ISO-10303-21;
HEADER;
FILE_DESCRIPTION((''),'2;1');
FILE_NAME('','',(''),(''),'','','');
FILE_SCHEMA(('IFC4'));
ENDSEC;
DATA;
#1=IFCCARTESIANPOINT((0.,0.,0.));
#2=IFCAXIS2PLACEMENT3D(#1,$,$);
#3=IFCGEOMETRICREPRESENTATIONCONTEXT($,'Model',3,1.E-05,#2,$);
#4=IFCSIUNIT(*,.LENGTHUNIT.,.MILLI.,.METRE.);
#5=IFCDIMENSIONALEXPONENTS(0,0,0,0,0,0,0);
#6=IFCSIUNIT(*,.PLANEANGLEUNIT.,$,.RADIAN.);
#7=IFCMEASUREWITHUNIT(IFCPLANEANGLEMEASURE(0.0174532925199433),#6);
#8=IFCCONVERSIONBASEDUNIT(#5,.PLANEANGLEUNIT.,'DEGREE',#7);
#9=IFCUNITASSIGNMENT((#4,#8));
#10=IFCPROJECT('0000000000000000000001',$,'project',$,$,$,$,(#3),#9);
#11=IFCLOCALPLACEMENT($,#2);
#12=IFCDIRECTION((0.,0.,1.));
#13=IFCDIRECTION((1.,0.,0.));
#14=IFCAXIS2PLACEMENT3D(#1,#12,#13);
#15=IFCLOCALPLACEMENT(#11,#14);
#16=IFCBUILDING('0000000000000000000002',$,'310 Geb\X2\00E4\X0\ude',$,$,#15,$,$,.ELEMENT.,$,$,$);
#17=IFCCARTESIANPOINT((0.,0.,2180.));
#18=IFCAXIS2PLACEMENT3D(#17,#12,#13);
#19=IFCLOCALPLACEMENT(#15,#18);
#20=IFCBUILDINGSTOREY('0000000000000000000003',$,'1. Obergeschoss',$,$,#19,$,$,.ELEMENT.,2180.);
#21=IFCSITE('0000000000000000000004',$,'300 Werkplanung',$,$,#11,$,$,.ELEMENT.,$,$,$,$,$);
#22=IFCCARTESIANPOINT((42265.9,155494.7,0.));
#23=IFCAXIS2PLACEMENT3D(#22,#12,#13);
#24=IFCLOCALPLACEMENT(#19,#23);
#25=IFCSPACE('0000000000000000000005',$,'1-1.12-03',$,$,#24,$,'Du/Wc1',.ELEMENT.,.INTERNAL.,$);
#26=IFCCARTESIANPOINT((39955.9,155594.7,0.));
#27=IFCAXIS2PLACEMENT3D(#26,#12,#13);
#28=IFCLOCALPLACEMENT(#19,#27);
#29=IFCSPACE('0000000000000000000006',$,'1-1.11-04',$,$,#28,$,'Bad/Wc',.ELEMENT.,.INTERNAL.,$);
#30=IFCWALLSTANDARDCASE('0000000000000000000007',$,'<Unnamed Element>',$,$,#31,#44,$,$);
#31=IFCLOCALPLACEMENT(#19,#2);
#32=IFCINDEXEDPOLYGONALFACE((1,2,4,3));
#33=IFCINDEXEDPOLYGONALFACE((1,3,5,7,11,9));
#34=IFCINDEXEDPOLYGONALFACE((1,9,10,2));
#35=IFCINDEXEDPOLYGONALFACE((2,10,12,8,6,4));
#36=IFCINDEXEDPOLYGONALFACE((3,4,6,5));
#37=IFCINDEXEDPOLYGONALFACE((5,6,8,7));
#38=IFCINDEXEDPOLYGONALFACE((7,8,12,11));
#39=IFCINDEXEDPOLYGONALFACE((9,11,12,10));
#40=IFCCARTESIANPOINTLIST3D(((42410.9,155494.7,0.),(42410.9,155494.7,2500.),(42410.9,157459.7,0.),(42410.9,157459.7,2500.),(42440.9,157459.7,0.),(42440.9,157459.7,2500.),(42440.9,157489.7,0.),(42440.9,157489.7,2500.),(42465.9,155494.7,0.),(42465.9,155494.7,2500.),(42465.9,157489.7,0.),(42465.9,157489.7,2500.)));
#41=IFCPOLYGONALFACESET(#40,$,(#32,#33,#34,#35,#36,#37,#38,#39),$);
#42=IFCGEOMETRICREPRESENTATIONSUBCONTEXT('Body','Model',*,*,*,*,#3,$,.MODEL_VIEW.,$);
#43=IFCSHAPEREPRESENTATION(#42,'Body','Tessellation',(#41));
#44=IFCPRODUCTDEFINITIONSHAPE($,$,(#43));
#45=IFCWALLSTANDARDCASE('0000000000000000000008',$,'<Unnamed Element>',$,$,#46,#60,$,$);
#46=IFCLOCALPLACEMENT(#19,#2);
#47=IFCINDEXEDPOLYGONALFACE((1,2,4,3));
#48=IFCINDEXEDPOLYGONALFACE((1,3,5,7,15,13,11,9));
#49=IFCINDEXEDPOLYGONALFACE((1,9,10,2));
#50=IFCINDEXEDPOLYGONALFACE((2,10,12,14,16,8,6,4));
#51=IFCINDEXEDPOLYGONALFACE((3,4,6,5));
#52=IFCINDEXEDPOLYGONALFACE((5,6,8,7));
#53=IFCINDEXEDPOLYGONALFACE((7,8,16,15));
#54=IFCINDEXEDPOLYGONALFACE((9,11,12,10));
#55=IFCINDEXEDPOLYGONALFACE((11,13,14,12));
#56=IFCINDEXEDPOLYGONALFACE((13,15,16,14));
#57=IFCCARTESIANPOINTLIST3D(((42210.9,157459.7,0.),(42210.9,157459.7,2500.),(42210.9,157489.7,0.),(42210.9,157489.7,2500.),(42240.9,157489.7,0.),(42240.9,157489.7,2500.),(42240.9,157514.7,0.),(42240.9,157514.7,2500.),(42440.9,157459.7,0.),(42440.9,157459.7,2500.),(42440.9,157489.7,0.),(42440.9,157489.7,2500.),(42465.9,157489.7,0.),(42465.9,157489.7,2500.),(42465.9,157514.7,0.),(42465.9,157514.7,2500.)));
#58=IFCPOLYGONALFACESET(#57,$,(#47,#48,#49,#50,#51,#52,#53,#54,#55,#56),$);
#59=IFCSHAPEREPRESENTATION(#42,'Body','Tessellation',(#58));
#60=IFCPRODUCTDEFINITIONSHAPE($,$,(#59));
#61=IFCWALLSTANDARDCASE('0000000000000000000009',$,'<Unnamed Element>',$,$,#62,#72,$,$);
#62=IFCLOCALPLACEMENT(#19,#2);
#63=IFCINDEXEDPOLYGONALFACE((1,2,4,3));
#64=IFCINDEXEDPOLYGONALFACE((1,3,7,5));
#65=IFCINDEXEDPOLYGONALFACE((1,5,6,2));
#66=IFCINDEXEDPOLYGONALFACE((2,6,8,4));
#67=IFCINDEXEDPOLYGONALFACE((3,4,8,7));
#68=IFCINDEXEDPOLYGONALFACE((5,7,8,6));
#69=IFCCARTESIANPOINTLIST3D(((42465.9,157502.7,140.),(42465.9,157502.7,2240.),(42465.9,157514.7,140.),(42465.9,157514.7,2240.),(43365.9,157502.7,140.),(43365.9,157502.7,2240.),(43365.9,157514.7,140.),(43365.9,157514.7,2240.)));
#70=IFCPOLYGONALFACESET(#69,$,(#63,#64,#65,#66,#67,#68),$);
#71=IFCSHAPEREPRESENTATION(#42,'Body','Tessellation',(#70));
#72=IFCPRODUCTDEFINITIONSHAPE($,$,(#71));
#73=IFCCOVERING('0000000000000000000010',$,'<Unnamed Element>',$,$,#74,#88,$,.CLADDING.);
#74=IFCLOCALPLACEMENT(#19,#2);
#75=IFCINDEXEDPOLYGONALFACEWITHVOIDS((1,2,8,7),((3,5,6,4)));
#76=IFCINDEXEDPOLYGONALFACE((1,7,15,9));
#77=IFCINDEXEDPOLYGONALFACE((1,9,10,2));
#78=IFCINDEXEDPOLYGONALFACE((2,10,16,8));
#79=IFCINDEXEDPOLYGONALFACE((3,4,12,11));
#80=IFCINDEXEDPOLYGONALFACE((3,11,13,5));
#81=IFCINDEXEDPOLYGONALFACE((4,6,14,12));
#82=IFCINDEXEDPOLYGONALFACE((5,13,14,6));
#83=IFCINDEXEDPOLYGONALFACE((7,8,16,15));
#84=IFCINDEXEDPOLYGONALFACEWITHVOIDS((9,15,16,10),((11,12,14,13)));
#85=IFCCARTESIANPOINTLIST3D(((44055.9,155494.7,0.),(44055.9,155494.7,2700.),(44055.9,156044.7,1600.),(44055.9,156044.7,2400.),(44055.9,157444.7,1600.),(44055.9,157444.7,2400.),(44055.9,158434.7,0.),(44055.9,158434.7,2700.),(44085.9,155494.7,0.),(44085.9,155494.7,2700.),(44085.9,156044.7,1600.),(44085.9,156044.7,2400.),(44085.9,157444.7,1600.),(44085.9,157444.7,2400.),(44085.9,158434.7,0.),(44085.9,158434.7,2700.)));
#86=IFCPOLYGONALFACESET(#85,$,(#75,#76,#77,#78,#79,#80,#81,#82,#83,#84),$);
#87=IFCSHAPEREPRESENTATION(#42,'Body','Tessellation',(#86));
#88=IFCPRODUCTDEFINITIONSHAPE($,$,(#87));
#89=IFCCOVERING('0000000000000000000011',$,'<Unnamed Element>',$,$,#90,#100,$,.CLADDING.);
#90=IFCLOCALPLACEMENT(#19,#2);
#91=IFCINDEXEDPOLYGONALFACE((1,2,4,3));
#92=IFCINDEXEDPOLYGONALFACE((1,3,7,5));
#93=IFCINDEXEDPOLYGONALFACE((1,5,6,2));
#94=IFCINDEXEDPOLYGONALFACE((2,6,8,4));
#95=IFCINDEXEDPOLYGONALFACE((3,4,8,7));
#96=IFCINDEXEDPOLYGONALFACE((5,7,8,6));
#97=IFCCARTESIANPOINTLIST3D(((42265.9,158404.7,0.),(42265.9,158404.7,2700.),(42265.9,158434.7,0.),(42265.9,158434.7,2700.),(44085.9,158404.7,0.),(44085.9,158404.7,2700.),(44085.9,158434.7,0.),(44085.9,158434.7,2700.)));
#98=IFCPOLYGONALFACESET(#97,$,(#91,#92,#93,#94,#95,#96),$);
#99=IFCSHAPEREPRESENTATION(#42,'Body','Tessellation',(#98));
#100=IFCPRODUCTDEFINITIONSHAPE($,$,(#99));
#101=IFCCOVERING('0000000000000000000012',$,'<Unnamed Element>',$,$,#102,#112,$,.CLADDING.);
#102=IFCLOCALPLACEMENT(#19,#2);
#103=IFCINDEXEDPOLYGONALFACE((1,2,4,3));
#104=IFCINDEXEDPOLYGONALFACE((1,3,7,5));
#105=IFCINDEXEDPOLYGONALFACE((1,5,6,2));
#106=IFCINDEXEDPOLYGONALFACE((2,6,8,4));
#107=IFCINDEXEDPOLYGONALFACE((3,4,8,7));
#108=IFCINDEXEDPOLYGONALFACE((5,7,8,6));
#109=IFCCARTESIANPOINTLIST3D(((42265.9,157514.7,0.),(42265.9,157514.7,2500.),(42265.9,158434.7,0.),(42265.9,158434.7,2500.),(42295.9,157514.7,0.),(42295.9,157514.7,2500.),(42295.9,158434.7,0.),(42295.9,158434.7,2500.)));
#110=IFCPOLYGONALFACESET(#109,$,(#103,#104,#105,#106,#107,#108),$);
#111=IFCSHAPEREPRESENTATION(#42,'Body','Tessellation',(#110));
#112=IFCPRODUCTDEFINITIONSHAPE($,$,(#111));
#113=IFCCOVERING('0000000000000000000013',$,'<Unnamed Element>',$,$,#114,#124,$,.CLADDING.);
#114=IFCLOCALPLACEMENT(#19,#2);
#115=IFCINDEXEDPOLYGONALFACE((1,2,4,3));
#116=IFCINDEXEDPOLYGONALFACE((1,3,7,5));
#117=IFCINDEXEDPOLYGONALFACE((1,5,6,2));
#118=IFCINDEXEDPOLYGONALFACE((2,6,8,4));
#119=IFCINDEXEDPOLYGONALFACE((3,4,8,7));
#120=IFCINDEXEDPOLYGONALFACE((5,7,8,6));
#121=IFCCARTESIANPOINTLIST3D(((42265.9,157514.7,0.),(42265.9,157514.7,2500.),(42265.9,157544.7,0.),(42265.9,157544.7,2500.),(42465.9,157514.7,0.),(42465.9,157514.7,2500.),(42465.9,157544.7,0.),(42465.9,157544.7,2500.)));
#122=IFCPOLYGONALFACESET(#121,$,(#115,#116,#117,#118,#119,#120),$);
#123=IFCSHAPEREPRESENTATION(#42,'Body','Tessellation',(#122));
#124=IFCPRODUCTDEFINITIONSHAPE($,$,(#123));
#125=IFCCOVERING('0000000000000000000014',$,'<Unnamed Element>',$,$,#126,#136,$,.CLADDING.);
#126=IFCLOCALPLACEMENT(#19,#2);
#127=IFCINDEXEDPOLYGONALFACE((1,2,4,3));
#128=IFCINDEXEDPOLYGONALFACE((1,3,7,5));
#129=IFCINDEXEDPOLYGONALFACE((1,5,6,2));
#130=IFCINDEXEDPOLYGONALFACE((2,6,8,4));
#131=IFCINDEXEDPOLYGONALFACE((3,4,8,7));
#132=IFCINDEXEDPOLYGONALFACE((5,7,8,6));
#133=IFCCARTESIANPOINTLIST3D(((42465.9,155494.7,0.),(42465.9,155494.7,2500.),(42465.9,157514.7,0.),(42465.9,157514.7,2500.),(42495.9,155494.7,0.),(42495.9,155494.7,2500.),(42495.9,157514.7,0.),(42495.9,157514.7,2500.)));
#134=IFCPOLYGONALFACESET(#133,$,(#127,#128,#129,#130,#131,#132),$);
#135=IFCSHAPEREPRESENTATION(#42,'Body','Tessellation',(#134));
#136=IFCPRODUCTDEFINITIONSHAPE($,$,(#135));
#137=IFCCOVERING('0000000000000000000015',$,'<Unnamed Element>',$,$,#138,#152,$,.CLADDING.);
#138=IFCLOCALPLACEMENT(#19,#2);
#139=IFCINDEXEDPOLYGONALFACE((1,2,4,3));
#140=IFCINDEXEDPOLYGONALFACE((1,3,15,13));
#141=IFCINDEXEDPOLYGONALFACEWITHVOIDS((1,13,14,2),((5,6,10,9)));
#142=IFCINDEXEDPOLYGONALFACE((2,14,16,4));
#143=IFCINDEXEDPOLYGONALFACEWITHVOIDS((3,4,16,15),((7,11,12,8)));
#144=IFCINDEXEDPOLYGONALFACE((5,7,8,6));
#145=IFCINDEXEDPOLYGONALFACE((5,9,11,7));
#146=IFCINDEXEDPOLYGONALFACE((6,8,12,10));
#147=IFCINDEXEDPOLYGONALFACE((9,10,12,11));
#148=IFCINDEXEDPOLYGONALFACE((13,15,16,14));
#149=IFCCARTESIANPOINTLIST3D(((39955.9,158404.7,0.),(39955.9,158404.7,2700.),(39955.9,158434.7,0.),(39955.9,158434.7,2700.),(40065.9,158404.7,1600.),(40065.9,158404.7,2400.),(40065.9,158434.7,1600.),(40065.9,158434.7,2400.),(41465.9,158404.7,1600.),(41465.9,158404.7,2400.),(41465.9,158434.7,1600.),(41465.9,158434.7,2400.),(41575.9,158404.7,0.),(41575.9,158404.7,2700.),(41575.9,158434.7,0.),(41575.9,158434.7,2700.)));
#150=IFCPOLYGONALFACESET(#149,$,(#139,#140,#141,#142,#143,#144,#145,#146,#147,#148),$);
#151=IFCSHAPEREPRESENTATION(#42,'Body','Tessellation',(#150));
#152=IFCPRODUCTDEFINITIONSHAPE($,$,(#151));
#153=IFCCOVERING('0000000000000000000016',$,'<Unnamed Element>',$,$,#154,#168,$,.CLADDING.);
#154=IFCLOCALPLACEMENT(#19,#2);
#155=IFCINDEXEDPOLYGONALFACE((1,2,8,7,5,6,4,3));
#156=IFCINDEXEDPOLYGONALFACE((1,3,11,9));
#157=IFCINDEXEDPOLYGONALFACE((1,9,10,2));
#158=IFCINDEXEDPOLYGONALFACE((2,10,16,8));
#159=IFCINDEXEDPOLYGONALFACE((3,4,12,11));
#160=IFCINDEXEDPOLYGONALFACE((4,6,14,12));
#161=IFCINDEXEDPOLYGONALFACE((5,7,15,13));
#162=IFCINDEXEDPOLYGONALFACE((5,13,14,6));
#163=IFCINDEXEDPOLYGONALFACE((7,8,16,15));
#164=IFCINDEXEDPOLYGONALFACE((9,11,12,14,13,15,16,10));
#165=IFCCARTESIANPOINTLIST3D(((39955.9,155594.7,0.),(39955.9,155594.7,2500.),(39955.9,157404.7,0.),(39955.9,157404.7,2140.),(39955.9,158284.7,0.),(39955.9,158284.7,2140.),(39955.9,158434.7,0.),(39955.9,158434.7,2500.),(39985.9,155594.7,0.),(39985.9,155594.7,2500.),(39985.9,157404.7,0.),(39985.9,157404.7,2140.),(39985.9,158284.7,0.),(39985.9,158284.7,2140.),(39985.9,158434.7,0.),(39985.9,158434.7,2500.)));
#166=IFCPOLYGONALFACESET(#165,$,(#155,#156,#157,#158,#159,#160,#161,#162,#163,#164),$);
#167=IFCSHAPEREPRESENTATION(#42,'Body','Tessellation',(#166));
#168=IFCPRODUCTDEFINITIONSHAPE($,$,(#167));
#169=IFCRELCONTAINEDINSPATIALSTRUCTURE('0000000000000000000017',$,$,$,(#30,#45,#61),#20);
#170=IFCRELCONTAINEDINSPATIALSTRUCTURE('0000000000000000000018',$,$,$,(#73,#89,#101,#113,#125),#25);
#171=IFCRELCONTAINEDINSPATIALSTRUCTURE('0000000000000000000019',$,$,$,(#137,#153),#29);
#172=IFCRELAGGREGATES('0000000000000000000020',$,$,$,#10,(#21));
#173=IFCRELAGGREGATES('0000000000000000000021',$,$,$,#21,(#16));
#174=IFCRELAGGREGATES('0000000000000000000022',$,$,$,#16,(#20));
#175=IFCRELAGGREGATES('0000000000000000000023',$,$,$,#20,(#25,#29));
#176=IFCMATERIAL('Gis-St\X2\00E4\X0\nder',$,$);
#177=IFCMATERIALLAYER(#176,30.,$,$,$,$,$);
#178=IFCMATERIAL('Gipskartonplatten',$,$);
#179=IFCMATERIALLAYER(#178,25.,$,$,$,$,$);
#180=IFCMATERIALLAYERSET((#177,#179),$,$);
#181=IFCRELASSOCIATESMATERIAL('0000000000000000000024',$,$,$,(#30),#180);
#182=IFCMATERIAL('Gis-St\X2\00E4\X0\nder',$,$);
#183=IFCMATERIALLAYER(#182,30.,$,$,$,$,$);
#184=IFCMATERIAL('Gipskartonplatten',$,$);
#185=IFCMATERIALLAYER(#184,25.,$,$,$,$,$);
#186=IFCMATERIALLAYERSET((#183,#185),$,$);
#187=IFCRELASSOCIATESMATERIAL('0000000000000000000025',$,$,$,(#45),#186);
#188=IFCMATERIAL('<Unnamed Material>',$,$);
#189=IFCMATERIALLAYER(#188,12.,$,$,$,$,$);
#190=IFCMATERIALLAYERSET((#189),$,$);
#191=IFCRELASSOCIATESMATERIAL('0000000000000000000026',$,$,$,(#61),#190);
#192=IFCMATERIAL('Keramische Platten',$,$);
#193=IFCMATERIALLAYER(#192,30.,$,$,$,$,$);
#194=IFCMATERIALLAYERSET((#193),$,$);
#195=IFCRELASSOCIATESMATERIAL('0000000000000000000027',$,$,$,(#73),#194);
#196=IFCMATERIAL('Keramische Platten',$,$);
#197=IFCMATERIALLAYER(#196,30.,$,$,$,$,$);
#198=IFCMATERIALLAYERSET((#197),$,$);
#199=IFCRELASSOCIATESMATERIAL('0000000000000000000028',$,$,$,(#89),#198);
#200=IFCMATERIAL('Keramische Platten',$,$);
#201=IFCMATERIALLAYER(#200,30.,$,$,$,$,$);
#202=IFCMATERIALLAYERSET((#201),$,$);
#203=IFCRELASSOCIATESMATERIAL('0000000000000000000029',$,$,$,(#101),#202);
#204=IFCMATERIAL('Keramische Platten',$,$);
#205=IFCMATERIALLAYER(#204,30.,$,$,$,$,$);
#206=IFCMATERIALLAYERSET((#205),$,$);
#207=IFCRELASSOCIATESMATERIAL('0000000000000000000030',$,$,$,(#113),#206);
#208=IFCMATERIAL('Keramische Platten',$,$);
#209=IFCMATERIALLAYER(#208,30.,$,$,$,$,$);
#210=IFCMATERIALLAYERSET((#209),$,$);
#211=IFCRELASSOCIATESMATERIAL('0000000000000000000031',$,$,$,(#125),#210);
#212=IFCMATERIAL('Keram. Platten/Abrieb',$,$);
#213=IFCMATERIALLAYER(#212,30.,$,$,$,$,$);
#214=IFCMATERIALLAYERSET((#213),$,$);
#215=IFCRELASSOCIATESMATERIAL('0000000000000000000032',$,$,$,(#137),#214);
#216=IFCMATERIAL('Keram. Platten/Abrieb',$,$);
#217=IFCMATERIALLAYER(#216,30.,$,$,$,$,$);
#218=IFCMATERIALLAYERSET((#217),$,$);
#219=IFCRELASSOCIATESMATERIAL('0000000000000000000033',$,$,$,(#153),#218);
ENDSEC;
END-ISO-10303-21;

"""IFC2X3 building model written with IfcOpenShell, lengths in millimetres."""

from ifc_helpers import new_model, entity, si_unit, converted_unit, frame, frame_2d, origin, origin_with_axes, place, context, subcontext, project, spatial, polyline, rectangle, outline, extrude, material, layer, layer_set, layer_usage, element, save


model = new_model("IFC2X3")

# Units and contexts
model_context = context("Model", 3, precision=1e-05, world=origin())
body_context = subcontext(model_context, "Body", "Model", "MODEL_VIEW")
ifc_project = project(units=[si_unit("LENGTHUNIT", "METRE", prefix="MILLI"), converted_unit("PLANEANGLEUNIT", "DEGREE", entity("IfcPlaneAngleMeasure", 0.0174532925199433), si_unit("PLANEANGLEUNIT", "RADIAN"), dimensions=[0, 0, 0, 0, 0, 0, 0])], contexts=[model_context])

# Site, building, storey
site_placement = place(None, origin())
site = spatial("IfcSite", under=ifc_project, at=site_placement, Name="300 Werkplanung", CompositionType="ELEMENT")
building_placement = place(site_placement, origin_with_axes())
building = spatial("IfcBuilding", under=site, at=building_placement, Name="310 Gebäude", CompositionType="ELEMENT")
storey_placement = place(building_placement, frame((0.0, 0.0, 2180.0), z_axis=(0.0, 0.0, 1.0), x_axis=(1.0, 0.0, 0.0)))
storey = spatial("IfcBuildingStorey", under=building, at=storey_placement, Name="1. Obergeschoss", CompositionType="ELEMENT", Elevation=2180.0)

# Walls
ifc_material_1 = material(Name="Gis-Ständer")
ifc_layer_1 = layer(ifc_material_1, 30.0)
ifc_material_2 = material(Name="Gipskartonplatten")
ifc_layer_2 = layer(ifc_material_2, 25.0)
ifc_layer_set_1 = layer_set([ifc_layer_1, ifc_layer_2])
ifc_layer_usage_1 = layer_usage(ifc_layer_set_1, "AXIS2", "POSITIVE", -55.0)
wall_1_placement = place(storey_placement, frame((42410.9, 157459.7, 0.0), z_axis=(0.0, 0.0, 1.0), x_axis=(0.0, -1.0, 0.0)))
element("IfcWallStandardCase", 1, at=wall_1_placement, inside=storey, material=ifc_layer_usage_1, Name="<Unnamed Element>", context=body_context, shape_type="SweptSolid", body=[
    extrude(outline(polyline([(-30.0, 55.0), (-30.0, 30.0), (0.0, 30.0), (0.0, 0.0), (1965.0, 0.0), (1965.0, 55.0), (-30.0, 55.0)])), origin_with_axes(), (0.0, 0.0, 1.0), 2500.0),
])
ifc_material_3 = material(Name="Gis-Ständer")
ifc_layer_3 = layer(ifc_material_3, 30.0)
ifc_material_4 = material(Name="Gipskartonplatten")
ifc_layer_4 = layer(ifc_material_4, 25.0)
ifc_layer_set_2 = layer_set([ifc_layer_3, ifc_layer_4])
ifc_layer_usage_2 = layer_usage(ifc_layer_set_2, "AXIS2", "POSITIVE", -55.0)
wall_2_placement = place(storey_placement, frame((42210.9, 157459.7, 0.0), z_axis=(0.0, 0.0, 1.0), x_axis=(1.0, 0.0, 0.0)))
element("IfcWallStandardCase", 2, at=wall_2_placement, inside=storey, material=ifc_layer_usage_2, Name="<Unnamed Element>", context=body_context, shape_type="SweptSolid", body=[
    extrude(outline(polyline([(0.0, 0.0), (230.0, 0.0), (230.0, 30.0), (255.0, 30.0), (255.0, 55.0), (30.0, 55.0), (30.0, 30.0), (0.0, 30.0), (0.0, 0.0)])), origin_with_axes(), (0.0, 0.0, 1.0), 2500.0),
])
ifc_material_5 = material(Name="<Unnamed Material>")
ifc_layer_5 = layer(ifc_material_5, 12.0)
ifc_layer_set_3 = layer_set([ifc_layer_5])
ifc_layer_usage_3 = layer_usage(ifc_layer_set_3, "AXIS2", "POSITIVE", 0.0)
wall_3_placement = place(storey_placement, frame((43365.9, 157514.7, 140.0), z_axis=(0.0, 0.0, 1.0), x_axis=(-1.0, 0.0, 0.0)))
element("IfcWallStandardCase", 3, at=wall_3_placement, inside=storey, material=ifc_layer_usage_3, Name="<Unnamed Element>", context=body_context, shape_type="SweptSolid", body=[
    extrude(rectangle(XDim=900.0, YDim=12.0, at=frame_2d((450.0, 6.0), x_axis=(1.0, 0.0))), origin_with_axes(), (0.0, 0.0, 1.0), 2100.0),
])

# Shared definitions
space_1_placement = place(storey_placement, frame((42265.9, 155494.7, 0.0), z_axis=(0.0, 0.0, 1.0), x_axis=(1.0, 0.0, 0.0)))
space_1 = spatial("IfcSpace", under=storey, at=space_1_placement, Name="1-1.12-03", LongName="Du/Wc1", CompositionType="ELEMENT", InteriorOrExteriorSpace="INTERNAL")

# Coverings
ifc_material_6 = material(Name="Keramische Platten")
ifc_layer_6 = layer(ifc_material_6, 30.0)
ifc_layer_set_4 = layer_set([ifc_layer_6])
ifc_layer_usage_4 = layer_usage(ifc_layer_set_4, "AXIS3", "POSITIVE", 0.0)
covering_1_placement = place(space_1_placement, frame((1820.0, 0.0, 0.0), z_axis=(0.0, 0.0, 1.0), x_axis=(0.0, 1.0, 0.0)))
element("IfcCovering", 4, at=covering_1_placement, inside=space_1, material=ifc_layer_usage_4, Name="<Unnamed Element>", PredefinedType="CLADDING", context=body_context, shape_type="SweptSolid", body=[
    extrude(outline(polyline([(2940.0, 0.0), (2940.0, -2700.0), (0.0, -2700.0), (0.0, 0.0), (2940.0, 0.0)]), holes=[polyline([(1950.0, -1600.0), (550.0, -1600.0), (550.0, -2400.0), (1950.0, -2400.0), (1950.0, -1600.0)])]), frame((0.0, 0.0, 0.0), z_axis=(0.0, 1.0, 0.0), x_axis=(1.0, 0.0, 0.0)), (0.0, 0.0, 1.0), 30.0),
])
ifc_material_7 = material(Name="Keramische Platten")
ifc_layer_7 = layer(ifc_material_7, 30.0)
ifc_layer_set_5 = layer_set([ifc_layer_7])
ifc_layer_usage_5 = layer_usage(ifc_layer_set_5, "AXIS3", "POSITIVE", 0.0)
covering_2_placement = place(space_1_placement, frame((1820.0, 2940.0, 0.0), z_axis=(0.0, 0.0, 1.0), x_axis=(-1.0, 0.0, 0.0)))
element("IfcCovering", 5, at=covering_2_placement, inside=space_1, material=ifc_layer_usage_5, Name="<Unnamed Element>", PredefinedType="CLADDING", context=body_context, shape_type="SweptSolid", body=[
    extrude(rectangle(XDim=2700.0, YDim=1820.0, at=frame_2d((-910.0, 1350.0), x_axis=(0.0, 1.0))), frame((1820.0, 0.0, 2700.0), z_axis=(0.0, 1.0, 0.0), x_axis=(1.0, 0.0, 0.0)), (0.0, 0.0, 1.0), 30.0),
])
ifc_material_8 = material(Name="Keramische Platten")
ifc_layer_8 = layer(ifc_material_8, 30.0)
ifc_layer_set_6 = layer_set([ifc_layer_8])
ifc_layer_usage_6 = layer_usage(ifc_layer_set_6, "AXIS3", "POSITIVE", 0.0)
covering_3_placement = place(space_1_placement, frame((0.0, 2940.0, 0.0), z_axis=(0.0, 0.0, 1.0), x_axis=(0.0, -1.0, 0.0)))
element("IfcCovering", 6, at=covering_3_placement, inside=space_1, material=ifc_layer_usage_6, Name="<Unnamed Element>", PredefinedType="CLADDING", context=body_context, shape_type="SweptSolid", body=[
    extrude(rectangle(XDim=2500.0, YDim=920.0, at=frame_2d((-460.0, 1250.0), x_axis=(0.0, 1.0))), frame((920.0, 0.0, 2500.0), z_axis=(0.0, 1.0, 0.0), x_axis=(1.0, 0.0, 0.0)), (0.0, 0.0, 1.0), 30.0),
])
ifc_material_9 = material(Name="Keramische Platten")
ifc_layer_9 = layer(ifc_material_9, 30.0)
ifc_layer_set_7 = layer_set([ifc_layer_9])
ifc_layer_usage_7 = layer_usage(ifc_layer_set_7, "AXIS3", "POSITIVE", 0.0)
covering_4_placement = place(space_1_placement, frame((0.0, 2020.0, 0.0), z_axis=(0.0, 0.0, 1.0), x_axis=(1.0, 0.0, 0.0)))
element("IfcCovering", 7, at=covering_4_placement, inside=space_1, material=ifc_layer_usage_7, Name="<Unnamed Element>", PredefinedType="CLADDING", context=body_context, shape_type="SweptSolid", body=[
    extrude(rectangle(XDim=2500.0, YDim=200.0, at=frame_2d((-100.0, 1250.0), x_axis=(0.0, 1.0))), frame((200.0, 0.0, 2500.0), z_axis=(0.0, 1.0, 0.0), x_axis=(1.0, 0.0, 0.0)), (0.0, 0.0, 1.0), 30.0),
])
ifc_material_10 = material(Name="Keramische Platten")
ifc_layer_10 = layer(ifc_material_10, 30.0)
ifc_layer_set_8 = layer_set([ifc_layer_10])
ifc_layer_usage_8 = layer_usage(ifc_layer_set_8, "AXIS3", "POSITIVE", 0.0)
covering_5_placement = place(space_1_placement, frame((200.0, 2020.0, 0.0), z_axis=(0.0, 0.0, 1.0), x_axis=(0.0, -1.0, 0.0)))
element("IfcCovering", 8, at=covering_5_placement, inside=space_1, material=ifc_layer_usage_8, Name="<Unnamed Element>", PredefinedType="CLADDING", context=body_context, shape_type="SweptSolid", body=[
    extrude(rectangle(XDim=2500.0, YDim=2020.0, at=frame_2d((-1010.0, 1250.0), x_axis=(0.0, 1.0))), frame((2020.0, 0.0, 2500.0), z_axis=(0.0, 1.0, 0.0), x_axis=(1.0, 0.0, 0.0)), (0.0, 0.0, 1.0), 30.0),
])

# Shared definitions
space_2_placement = place(storey_placement, frame((39955.9, 155594.7, 0.0), z_axis=(0.0, 0.0, 1.0), x_axis=(1.0, 0.0, 0.0)))
space_2 = spatial("IfcSpace", under=storey, at=space_2_placement, Name="1-1.11-04", LongName="Bad/Wc", CompositionType="ELEMENT", InteriorOrExteriorSpace="INTERNAL")

# Coverings
ifc_material_11 = material(Name="Keram. Platten/Abrieb")
ifc_layer_11 = layer(ifc_material_11, 30.0)
ifc_layer_set_9 = layer_set([ifc_layer_11])
ifc_layer_usage_9 = layer_usage(ifc_layer_set_9, "AXIS3", "POSITIVE", 0.0)
covering_6_placement = place(space_2_placement, frame((1620.0, 2840.0, 0.0), z_axis=(0.0, 0.0, 1.0), x_axis=(-1.0, 0.0, 0.0)))
element("IfcCovering", 9, at=covering_6_placement, inside=space_2, material=ifc_layer_usage_9, Name="<Unnamed Element>", PredefinedType="CLADDING", context=body_context, shape_type="SweptSolid", body=[
    extrude(outline(polyline([(1620.0, 0.0), (1620.0, -2700.0), (0.0, -2700.0), (0.0, 0.0), (1620.0, 0.0)]), holes=[polyline([(1510.0, -1600.0), (110.0, -1600.0), (110.0, -2400.0), (1510.0, -2400.0), (1510.0, -1600.0)])]), frame((0.0, 0.0, 0.0), z_axis=(0.0, 1.0, 0.0), x_axis=(1.0, 0.0, 0.0)), (0.0, 0.0, 1.0), 30.0),
])
ifc_material_12 = material(Name="Keram. Platten/Abrieb")
ifc_layer_12 = layer(ifc_material_12, 30.0)
ifc_layer_set_10 = layer_set([ifc_layer_12])
ifc_layer_usage_10 = layer_usage(ifc_layer_set_10, "AXIS3", "POSITIVE", 0.0)
covering_7_placement = place(space_2_placement, frame((0.0, 2840.0, 0.0), z_axis=(0.0, 0.0, 1.0), x_axis=(0.0, -1.0, 0.0)))
element("IfcCovering", 10, at=covering_7_placement, inside=space_2, material=ifc_layer_usage_10, Name="<Unnamed Element>", PredefinedType="CLADDING", context=body_context, shape_type="SweptSolid", body=[
    extrude(outline(polyline([(2840.0, 0.0), (2840.0, -2500.0), (0.0, -2500.0), (0.0, 0.0), (150.0, 0.0), (150.0, -2140.0), (1030.0, -2140.0), (1030.0, 0.0), (2840.0, 0.0)])), frame((0.0, 0.0, 0.0), z_axis=(0.0, 1.0, 0.0), x_axis=(1.0, 0.0, 0.0)), (0.0, 0.0, 1.0), 30.0),
])

save(model, "model.ifc")
